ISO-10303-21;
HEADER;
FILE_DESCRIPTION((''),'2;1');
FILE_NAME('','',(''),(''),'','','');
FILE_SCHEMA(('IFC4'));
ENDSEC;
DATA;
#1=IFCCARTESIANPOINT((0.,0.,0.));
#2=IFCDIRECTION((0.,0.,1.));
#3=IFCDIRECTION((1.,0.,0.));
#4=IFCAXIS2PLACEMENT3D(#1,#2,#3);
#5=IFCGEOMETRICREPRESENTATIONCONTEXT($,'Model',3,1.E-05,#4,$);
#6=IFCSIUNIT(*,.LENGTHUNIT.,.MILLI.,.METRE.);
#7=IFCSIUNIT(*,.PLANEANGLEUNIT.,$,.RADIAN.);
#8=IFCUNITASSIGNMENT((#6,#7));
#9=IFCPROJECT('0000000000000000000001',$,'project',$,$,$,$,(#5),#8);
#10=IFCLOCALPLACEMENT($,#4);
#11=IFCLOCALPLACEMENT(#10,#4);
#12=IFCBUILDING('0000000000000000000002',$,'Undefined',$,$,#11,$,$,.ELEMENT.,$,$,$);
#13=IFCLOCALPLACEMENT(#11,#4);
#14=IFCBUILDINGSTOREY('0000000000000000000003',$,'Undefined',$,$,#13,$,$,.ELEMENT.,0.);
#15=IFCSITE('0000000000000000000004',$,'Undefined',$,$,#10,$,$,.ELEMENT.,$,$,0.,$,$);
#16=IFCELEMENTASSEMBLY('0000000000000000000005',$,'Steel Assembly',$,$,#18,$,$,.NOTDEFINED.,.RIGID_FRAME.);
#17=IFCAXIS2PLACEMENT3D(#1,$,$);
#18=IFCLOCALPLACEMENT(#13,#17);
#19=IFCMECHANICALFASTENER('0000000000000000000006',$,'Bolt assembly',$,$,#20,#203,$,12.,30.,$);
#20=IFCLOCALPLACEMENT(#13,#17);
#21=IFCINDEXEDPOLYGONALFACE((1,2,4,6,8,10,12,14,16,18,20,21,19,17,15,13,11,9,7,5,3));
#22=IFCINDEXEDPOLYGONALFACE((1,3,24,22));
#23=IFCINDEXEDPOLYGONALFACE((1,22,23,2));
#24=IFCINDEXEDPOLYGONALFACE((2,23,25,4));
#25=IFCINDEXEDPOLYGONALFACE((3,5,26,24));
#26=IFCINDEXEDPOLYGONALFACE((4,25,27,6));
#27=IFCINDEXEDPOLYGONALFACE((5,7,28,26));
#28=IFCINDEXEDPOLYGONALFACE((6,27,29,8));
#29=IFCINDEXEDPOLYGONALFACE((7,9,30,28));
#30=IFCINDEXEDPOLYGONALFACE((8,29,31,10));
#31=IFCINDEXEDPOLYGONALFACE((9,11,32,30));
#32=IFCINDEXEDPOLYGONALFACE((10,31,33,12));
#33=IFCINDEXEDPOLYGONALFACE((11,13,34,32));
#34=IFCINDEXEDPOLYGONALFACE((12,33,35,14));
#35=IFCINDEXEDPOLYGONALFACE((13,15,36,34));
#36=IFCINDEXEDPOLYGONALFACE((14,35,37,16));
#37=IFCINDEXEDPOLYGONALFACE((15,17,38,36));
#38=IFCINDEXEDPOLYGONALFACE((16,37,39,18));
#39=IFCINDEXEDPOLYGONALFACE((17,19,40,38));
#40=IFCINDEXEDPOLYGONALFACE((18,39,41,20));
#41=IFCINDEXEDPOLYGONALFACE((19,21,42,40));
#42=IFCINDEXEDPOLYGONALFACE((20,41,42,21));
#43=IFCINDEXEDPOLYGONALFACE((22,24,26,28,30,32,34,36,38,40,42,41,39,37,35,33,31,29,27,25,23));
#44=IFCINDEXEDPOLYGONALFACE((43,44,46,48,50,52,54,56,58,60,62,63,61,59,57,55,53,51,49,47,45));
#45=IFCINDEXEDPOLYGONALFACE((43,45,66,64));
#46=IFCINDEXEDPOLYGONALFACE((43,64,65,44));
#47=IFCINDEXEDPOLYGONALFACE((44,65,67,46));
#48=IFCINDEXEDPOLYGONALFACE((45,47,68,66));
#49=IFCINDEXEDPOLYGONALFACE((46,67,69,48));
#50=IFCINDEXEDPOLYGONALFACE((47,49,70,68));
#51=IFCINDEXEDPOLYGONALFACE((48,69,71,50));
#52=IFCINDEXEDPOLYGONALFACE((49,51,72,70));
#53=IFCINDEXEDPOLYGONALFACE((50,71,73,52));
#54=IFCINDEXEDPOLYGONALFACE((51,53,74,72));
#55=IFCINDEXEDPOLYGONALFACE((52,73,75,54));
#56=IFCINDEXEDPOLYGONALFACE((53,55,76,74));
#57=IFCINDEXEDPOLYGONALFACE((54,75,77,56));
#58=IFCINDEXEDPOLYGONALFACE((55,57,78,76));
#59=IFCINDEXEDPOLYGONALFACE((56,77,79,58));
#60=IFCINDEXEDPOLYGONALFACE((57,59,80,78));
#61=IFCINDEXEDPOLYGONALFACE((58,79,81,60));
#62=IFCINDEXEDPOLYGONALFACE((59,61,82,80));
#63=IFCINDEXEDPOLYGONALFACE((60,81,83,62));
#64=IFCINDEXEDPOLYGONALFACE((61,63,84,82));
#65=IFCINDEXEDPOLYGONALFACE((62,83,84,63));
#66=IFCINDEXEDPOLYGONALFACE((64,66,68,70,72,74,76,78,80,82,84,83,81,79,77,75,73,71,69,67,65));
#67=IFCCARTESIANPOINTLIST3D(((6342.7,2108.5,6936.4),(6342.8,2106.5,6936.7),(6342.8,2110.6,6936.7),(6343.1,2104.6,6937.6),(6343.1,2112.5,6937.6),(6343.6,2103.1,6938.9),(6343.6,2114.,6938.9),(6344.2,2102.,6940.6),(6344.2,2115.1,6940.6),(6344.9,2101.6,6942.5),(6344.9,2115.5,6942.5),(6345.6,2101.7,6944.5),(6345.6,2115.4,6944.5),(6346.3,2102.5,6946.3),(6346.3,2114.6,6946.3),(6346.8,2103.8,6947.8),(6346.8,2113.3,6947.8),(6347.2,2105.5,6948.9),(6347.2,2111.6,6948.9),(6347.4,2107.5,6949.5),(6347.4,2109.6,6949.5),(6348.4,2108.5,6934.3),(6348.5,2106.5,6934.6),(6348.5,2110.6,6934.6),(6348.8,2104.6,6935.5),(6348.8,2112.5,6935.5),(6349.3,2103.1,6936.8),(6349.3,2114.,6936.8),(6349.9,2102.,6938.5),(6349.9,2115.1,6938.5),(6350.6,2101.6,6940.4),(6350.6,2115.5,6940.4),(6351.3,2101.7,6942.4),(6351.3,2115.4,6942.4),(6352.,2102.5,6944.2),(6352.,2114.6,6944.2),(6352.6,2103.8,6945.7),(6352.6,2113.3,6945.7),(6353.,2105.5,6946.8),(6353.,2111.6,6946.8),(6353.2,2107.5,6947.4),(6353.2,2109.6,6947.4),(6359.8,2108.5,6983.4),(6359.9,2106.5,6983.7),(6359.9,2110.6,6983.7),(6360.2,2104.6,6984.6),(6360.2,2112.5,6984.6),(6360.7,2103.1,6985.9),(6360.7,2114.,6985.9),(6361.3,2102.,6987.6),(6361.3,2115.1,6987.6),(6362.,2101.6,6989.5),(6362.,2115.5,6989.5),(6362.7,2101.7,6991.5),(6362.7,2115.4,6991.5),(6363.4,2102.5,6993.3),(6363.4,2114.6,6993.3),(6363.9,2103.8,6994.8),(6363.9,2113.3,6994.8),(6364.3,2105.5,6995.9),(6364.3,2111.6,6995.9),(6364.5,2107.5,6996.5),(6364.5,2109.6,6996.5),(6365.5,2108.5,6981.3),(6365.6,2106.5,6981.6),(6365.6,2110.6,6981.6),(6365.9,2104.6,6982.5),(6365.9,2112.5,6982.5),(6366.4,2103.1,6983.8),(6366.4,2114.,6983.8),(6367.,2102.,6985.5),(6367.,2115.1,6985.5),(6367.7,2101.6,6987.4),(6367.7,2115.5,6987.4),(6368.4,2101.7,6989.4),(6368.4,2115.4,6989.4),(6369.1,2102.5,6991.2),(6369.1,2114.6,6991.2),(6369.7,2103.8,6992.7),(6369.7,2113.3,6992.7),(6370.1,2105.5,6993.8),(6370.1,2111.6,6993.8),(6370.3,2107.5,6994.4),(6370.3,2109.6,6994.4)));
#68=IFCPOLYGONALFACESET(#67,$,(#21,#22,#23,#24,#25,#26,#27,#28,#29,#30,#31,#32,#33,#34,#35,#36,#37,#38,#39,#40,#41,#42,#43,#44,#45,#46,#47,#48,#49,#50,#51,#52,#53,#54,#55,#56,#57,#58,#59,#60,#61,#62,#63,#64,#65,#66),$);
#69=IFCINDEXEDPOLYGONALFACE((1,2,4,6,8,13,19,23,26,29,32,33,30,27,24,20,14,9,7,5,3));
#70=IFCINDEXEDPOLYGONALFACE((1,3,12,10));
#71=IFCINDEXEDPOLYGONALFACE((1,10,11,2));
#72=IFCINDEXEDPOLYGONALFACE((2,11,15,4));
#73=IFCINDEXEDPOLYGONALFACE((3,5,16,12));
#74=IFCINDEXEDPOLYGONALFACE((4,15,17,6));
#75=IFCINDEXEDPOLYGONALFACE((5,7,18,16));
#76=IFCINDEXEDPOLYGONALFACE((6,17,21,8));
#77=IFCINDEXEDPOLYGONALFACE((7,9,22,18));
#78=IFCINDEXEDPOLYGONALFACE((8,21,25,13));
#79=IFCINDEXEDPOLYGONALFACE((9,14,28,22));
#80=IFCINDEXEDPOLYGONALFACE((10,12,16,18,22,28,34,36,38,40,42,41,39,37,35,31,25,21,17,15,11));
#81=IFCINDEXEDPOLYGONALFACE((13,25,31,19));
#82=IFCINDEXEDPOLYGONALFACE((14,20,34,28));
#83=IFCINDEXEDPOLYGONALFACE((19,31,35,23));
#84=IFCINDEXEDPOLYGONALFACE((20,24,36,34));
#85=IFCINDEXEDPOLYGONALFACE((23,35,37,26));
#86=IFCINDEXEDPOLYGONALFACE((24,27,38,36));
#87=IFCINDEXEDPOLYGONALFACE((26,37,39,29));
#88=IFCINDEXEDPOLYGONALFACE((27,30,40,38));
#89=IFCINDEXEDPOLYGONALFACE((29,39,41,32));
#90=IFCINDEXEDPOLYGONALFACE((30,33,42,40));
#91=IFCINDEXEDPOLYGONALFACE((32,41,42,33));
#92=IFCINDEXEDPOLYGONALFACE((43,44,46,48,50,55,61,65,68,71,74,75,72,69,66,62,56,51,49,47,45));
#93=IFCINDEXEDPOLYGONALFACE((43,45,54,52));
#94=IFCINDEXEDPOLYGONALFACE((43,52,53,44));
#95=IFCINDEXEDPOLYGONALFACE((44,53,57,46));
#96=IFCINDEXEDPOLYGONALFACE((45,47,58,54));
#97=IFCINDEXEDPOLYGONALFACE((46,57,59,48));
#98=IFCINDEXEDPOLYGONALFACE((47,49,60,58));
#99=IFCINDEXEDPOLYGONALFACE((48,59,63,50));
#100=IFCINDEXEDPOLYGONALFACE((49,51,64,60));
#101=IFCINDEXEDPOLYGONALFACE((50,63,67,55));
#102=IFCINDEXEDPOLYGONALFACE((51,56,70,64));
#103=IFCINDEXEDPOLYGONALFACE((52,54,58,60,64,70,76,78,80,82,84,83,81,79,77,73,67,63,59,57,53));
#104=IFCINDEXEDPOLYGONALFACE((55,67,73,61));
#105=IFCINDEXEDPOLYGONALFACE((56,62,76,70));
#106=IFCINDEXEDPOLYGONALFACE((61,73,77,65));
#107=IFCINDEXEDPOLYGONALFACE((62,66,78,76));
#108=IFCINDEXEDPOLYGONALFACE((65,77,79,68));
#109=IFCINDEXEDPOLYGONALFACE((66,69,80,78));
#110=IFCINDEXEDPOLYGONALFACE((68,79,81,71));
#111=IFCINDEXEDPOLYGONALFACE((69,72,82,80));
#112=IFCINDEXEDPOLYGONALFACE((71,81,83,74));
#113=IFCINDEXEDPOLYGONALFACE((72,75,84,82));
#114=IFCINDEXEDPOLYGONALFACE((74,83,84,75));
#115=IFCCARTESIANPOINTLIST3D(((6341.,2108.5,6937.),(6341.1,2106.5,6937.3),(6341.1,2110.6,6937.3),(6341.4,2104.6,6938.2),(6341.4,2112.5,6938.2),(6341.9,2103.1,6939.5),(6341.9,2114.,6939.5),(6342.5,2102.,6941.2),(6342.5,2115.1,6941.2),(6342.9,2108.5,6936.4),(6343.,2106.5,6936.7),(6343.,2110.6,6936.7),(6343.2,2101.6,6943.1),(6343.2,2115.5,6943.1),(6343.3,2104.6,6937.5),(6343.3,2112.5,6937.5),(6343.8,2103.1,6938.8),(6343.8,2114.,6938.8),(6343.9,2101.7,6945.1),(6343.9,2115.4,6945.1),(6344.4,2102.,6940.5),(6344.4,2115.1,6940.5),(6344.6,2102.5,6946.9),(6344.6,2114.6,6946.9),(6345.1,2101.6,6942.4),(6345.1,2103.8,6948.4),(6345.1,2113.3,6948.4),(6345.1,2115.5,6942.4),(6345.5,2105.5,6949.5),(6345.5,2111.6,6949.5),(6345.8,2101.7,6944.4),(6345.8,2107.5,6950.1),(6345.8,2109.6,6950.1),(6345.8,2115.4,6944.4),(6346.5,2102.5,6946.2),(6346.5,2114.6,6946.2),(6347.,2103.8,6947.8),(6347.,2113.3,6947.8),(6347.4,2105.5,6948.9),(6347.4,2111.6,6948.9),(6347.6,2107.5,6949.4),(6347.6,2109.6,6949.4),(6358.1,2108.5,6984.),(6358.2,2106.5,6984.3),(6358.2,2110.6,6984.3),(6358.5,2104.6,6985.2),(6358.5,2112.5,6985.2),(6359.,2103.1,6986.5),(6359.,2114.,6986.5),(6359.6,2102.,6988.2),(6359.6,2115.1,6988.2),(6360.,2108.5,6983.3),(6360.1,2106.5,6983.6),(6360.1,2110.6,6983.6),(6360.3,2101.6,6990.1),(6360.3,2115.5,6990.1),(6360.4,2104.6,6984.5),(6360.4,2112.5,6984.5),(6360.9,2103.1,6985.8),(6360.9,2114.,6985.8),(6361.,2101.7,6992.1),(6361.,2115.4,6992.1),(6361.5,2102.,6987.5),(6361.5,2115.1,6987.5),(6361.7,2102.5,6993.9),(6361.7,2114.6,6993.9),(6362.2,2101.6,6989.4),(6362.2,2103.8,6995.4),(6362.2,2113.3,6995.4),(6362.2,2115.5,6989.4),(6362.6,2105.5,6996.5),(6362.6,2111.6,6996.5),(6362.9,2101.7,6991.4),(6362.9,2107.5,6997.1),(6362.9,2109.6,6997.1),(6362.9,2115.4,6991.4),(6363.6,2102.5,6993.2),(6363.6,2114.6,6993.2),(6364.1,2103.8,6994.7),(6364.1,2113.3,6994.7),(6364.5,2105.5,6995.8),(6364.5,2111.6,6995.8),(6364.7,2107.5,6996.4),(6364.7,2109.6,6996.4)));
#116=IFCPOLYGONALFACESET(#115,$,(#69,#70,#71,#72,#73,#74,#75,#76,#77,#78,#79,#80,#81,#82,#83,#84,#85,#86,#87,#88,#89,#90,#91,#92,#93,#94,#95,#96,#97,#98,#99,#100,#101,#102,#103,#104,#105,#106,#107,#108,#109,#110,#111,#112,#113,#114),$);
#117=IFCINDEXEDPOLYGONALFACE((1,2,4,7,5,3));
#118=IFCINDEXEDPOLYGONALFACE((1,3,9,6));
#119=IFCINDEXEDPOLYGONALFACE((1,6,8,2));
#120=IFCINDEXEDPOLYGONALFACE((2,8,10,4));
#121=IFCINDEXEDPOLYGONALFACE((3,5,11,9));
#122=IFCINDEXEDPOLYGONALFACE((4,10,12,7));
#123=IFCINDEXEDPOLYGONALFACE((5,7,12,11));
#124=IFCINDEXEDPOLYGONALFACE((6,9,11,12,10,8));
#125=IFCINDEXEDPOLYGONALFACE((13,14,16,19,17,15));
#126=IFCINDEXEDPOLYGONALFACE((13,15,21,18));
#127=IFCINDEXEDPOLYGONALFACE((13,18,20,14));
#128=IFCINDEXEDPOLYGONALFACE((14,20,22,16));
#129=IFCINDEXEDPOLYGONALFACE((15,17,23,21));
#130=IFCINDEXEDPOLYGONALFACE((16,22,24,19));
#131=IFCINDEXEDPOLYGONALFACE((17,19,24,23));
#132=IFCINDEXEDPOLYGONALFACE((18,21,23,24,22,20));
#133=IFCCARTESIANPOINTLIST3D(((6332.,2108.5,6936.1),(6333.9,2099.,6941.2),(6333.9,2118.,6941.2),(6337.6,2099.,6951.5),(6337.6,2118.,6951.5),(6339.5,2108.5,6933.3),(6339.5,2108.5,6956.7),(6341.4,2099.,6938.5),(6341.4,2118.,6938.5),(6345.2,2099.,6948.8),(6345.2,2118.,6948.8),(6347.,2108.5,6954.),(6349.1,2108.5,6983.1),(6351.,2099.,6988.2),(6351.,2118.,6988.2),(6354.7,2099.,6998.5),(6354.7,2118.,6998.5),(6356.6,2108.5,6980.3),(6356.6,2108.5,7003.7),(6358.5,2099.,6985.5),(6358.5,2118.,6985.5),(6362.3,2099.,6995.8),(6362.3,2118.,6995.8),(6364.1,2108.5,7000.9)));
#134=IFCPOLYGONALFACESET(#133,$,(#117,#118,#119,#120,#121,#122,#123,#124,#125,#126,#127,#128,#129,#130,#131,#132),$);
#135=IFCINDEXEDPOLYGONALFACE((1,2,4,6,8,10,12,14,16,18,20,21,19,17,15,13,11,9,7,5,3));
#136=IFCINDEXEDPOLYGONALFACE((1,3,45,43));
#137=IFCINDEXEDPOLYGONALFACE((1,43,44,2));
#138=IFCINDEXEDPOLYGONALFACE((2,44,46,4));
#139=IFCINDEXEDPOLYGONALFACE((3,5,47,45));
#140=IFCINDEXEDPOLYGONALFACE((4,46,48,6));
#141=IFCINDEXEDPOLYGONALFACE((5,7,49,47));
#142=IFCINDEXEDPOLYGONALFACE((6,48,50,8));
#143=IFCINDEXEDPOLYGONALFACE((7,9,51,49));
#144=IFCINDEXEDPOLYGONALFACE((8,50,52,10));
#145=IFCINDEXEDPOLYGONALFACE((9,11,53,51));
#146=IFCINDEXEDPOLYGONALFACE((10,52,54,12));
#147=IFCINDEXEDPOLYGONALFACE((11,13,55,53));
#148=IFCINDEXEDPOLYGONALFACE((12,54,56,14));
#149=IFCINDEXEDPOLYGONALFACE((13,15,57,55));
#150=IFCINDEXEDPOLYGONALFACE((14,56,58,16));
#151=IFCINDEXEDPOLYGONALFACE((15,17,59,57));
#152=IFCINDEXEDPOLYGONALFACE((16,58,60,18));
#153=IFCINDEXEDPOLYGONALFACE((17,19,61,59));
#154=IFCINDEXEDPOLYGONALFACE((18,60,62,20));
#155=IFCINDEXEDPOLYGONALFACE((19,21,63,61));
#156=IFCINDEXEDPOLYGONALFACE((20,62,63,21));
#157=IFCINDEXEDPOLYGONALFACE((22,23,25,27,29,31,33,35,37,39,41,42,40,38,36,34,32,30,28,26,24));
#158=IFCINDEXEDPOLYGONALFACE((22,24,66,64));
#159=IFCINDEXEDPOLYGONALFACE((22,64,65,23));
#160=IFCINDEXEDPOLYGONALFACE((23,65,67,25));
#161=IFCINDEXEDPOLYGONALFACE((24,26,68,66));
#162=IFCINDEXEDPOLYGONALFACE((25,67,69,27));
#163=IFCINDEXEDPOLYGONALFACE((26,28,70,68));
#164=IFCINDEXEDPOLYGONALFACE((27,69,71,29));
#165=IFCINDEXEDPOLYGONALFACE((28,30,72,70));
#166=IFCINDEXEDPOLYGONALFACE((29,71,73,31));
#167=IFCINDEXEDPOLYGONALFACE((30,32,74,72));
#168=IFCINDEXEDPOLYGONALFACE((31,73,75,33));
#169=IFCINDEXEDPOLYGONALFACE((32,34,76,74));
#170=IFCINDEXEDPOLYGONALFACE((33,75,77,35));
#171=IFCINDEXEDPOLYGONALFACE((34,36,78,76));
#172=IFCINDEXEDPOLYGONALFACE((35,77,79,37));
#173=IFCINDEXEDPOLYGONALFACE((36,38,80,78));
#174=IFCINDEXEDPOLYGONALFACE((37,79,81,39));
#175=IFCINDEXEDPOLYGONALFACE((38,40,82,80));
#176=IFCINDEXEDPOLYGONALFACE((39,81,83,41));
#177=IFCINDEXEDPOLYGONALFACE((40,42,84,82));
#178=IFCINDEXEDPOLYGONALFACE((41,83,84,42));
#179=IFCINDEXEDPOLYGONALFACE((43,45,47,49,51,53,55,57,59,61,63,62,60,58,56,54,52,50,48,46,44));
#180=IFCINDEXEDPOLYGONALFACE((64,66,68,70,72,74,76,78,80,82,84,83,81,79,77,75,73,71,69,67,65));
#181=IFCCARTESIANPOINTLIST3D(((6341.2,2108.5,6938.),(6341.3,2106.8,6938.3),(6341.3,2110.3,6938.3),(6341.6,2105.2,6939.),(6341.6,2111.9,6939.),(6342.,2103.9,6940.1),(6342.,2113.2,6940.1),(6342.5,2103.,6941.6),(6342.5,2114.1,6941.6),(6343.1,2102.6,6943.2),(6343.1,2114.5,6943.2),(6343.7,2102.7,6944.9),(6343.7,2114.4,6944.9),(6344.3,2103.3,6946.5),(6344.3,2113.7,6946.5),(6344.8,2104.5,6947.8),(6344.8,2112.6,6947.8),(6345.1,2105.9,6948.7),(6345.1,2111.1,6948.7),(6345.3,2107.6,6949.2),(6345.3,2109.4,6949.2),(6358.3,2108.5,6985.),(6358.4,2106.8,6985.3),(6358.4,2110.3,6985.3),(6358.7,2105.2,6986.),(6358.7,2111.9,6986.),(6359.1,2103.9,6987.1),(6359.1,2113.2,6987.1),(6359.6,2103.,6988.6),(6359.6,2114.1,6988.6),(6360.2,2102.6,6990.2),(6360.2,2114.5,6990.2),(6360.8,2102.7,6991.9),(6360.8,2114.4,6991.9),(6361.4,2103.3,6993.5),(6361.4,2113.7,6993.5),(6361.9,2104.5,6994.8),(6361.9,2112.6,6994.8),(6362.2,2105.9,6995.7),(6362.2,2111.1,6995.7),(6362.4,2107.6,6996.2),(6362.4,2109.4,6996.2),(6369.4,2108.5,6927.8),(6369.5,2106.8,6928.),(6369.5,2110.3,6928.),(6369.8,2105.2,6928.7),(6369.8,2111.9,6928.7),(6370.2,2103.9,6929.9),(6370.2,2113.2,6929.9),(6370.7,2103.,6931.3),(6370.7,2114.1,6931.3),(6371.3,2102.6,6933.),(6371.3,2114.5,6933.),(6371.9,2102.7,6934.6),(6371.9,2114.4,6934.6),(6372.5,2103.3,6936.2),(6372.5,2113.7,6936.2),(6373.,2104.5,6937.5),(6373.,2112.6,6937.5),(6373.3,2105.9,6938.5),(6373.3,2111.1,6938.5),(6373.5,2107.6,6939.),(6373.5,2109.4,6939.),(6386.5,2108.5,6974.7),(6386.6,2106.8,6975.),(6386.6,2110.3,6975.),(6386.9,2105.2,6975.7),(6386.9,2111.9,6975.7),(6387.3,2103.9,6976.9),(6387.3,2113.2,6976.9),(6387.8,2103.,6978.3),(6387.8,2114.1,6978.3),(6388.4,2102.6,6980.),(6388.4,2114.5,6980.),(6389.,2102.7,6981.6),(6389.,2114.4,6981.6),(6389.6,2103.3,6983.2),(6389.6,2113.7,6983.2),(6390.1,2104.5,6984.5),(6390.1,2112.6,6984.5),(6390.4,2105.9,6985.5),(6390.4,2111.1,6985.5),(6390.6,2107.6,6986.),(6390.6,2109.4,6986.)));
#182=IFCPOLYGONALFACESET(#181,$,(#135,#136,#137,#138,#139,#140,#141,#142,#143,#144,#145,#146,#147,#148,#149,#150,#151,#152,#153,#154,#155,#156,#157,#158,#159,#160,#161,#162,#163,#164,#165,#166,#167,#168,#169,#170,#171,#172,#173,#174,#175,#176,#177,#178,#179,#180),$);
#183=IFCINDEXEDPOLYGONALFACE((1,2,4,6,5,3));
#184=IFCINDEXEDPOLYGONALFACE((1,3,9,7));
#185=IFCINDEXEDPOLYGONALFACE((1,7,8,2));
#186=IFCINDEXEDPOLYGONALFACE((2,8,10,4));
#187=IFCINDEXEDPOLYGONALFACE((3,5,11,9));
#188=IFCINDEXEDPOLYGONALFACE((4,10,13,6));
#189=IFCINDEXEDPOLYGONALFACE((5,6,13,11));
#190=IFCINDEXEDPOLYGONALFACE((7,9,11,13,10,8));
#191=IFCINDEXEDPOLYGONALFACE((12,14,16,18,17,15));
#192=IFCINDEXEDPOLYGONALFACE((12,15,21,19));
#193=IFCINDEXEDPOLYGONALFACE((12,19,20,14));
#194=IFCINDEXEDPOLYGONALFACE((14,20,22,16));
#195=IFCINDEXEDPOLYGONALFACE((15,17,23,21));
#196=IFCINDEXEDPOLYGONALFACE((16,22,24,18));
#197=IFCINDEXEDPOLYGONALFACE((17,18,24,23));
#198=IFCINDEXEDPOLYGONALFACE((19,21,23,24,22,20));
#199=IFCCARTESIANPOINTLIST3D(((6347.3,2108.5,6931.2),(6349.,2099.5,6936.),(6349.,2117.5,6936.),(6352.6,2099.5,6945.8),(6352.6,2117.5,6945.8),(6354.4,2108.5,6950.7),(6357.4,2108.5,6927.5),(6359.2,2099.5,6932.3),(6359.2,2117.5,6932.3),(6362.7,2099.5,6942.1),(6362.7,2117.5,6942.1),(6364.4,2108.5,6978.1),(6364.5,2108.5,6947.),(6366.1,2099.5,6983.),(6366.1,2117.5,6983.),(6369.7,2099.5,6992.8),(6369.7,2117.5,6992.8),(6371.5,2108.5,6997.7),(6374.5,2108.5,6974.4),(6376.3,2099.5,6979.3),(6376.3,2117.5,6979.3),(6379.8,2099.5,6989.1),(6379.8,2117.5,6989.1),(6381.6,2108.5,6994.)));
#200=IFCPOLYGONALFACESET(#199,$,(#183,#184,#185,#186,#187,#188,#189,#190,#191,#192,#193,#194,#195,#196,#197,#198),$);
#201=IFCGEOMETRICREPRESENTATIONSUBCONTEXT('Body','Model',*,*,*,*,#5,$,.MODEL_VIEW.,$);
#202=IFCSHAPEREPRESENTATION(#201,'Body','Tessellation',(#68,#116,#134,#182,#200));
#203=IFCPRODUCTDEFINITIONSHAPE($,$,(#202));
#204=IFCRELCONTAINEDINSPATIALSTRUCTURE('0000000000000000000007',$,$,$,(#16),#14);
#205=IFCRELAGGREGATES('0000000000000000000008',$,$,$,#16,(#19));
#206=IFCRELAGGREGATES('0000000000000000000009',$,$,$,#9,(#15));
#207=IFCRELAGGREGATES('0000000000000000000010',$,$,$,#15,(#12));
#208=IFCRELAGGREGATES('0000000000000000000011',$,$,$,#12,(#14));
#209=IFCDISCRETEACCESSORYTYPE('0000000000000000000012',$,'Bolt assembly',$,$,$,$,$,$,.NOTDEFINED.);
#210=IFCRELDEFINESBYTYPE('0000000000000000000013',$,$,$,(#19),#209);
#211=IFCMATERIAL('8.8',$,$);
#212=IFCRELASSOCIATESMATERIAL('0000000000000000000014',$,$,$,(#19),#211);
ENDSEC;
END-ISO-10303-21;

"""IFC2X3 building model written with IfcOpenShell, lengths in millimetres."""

from ifc_helpers import new_model, si_unit, frame, origin_with_axes, origin_2d_with_axis, place, context, subcontext, project, spatial, polyline, circle, outline, extrude, source, transform, mapped, material, type_object, element, aggregate, save


model = new_model("IFC2X3")

# Units and contexts
model_context = context("Model", 3, precision=1e-05, world=origin_with_axes())
body_context = subcontext(model_context, "Body", "Model", "MODEL_VIEW")
ifc_project = project(units=[si_unit("LENGTHUNIT", "METRE", prefix="MILLI"), si_unit("PLANEANGLEUNIT", "RADIAN")], contexts=[model_context])

# Site, building, storey
site_placement = place(None, origin_with_axes())
site = spatial("IfcSite", under=ifc_project, at=site_placement, Name="Undefined", CompositionType="ELEMENT", RefElevation=0.0)
building_placement = place(site_placement, origin_with_axes())
building = spatial("IfcBuilding", under=site, at=building_placement, Name="Undefined", CompositionType="ELEMENT")
storey_placement = place(building_placement, origin_with_axes())
storey = spatial("IfcBuildingStorey", under=building, at=storey_placement, Name="Undefined", CompositionType="ELEMENT", Elevation=0.0)

# Element assembly
assembly_1_placement = place(storey_placement, origin_with_axes())
assembly_1 = element("IfcElementAssembly", 1, at=assembly_1_placement, inside=storey, Name="Steel Assembly", AssemblyPlace="NOTDEFINED", PredefinedType="RIGID_FRAME")

# Mechanical fastener
ifc_material_1 = material(Name="8.8")
discrete_accessory_type_1 = type_object("IfcDiscreteAccessoryType", Name="Bolt assembly")
shared_shape_1 = source(origin_with_axes(), body_context, "Body", "SweptSolid", [
    extrude(circle(Radius=7.0, at=origin_2d_with_axis()), frame((0.0, -6.1, 0.0), z_axis=(0.0, 1.0, 0.0), x_axis=(1.0, 0.0, 0.0)), (0.0, 0.0, 1.0), 6.1),
    extrude(circle(Radius=7.0, at=origin_2d_with_axis()), frame((0.0, -7.9, 0.0), z_axis=(0.0, 1.0, 0.0), x_axis=(1.0, 0.0, 0.0)), (0.0, 0.0, 1.0), 2.0),
    extrude(outline(polyline([(11.0, 0.0), (5.5, 9.5), (-5.5, 9.5), (-11.0, 0.0), (-5.5, -9.5), (5.5, -9.5), (11.0, 0.0)])), frame((0.0, -16.0, 0.0), z_axis=(0.0, 1.0, 0.0), x_axis=(1.0, 0.0, 0.0)), (0.0, 0.0, 1.0), 8.0),
    extrude(circle(Radius=6.0, at=origin_2d_with_axis()), frame((0.0, -8.0, 0.0), z_axis=(0.0, 1.0, 0.0), x_axis=(1.0, 0.0, 0.0)), (0.0, 0.0, 1.0), 30.0),
    extrude(outline(polyline([(10.4, 0.0), (5.2, 9.0), (-5.2, 9.0), (-10.4, 0.0), (-5.2, -9.0), (5.2, -9.0), (10.4, 0.0)])), frame((0.0, 0.0, 0.0), z_axis=(0.0, 1.0, 0.0), x_axis=(1.0, 0.0, 0.0)), (0.0, 0.0, 1.0), 10.8),
])
mechanical_fastener_1_placement = place(assembly_1_placement, frame((6367.9, 2108.5, 6987.9), z_axis=(0.0, -1.0, 0.0), x_axis=(-0.34202, 0.0, -0.939693)))
mechanical_fastener_1 = element("IfcMechanicalFastener", 2, at=mechanical_fastener_1_placement, type_object=discrete_accessory_type_1, material=ifc_material_1, Name="Bolt assembly", NominalDiameter=12.0, NominalLength=30.0, context=body_context, shape_type="MappedRepresentation", body=[
    mapped(shared_shape_1, transform((0.0, 0.0, 0.0))),
    mapped(shared_shape_1, transform((50.0, 0.0, 0.0))),
])

aggregate(assembly_1, [mechanical_fastener_1])

save(model, "model.ifc")
